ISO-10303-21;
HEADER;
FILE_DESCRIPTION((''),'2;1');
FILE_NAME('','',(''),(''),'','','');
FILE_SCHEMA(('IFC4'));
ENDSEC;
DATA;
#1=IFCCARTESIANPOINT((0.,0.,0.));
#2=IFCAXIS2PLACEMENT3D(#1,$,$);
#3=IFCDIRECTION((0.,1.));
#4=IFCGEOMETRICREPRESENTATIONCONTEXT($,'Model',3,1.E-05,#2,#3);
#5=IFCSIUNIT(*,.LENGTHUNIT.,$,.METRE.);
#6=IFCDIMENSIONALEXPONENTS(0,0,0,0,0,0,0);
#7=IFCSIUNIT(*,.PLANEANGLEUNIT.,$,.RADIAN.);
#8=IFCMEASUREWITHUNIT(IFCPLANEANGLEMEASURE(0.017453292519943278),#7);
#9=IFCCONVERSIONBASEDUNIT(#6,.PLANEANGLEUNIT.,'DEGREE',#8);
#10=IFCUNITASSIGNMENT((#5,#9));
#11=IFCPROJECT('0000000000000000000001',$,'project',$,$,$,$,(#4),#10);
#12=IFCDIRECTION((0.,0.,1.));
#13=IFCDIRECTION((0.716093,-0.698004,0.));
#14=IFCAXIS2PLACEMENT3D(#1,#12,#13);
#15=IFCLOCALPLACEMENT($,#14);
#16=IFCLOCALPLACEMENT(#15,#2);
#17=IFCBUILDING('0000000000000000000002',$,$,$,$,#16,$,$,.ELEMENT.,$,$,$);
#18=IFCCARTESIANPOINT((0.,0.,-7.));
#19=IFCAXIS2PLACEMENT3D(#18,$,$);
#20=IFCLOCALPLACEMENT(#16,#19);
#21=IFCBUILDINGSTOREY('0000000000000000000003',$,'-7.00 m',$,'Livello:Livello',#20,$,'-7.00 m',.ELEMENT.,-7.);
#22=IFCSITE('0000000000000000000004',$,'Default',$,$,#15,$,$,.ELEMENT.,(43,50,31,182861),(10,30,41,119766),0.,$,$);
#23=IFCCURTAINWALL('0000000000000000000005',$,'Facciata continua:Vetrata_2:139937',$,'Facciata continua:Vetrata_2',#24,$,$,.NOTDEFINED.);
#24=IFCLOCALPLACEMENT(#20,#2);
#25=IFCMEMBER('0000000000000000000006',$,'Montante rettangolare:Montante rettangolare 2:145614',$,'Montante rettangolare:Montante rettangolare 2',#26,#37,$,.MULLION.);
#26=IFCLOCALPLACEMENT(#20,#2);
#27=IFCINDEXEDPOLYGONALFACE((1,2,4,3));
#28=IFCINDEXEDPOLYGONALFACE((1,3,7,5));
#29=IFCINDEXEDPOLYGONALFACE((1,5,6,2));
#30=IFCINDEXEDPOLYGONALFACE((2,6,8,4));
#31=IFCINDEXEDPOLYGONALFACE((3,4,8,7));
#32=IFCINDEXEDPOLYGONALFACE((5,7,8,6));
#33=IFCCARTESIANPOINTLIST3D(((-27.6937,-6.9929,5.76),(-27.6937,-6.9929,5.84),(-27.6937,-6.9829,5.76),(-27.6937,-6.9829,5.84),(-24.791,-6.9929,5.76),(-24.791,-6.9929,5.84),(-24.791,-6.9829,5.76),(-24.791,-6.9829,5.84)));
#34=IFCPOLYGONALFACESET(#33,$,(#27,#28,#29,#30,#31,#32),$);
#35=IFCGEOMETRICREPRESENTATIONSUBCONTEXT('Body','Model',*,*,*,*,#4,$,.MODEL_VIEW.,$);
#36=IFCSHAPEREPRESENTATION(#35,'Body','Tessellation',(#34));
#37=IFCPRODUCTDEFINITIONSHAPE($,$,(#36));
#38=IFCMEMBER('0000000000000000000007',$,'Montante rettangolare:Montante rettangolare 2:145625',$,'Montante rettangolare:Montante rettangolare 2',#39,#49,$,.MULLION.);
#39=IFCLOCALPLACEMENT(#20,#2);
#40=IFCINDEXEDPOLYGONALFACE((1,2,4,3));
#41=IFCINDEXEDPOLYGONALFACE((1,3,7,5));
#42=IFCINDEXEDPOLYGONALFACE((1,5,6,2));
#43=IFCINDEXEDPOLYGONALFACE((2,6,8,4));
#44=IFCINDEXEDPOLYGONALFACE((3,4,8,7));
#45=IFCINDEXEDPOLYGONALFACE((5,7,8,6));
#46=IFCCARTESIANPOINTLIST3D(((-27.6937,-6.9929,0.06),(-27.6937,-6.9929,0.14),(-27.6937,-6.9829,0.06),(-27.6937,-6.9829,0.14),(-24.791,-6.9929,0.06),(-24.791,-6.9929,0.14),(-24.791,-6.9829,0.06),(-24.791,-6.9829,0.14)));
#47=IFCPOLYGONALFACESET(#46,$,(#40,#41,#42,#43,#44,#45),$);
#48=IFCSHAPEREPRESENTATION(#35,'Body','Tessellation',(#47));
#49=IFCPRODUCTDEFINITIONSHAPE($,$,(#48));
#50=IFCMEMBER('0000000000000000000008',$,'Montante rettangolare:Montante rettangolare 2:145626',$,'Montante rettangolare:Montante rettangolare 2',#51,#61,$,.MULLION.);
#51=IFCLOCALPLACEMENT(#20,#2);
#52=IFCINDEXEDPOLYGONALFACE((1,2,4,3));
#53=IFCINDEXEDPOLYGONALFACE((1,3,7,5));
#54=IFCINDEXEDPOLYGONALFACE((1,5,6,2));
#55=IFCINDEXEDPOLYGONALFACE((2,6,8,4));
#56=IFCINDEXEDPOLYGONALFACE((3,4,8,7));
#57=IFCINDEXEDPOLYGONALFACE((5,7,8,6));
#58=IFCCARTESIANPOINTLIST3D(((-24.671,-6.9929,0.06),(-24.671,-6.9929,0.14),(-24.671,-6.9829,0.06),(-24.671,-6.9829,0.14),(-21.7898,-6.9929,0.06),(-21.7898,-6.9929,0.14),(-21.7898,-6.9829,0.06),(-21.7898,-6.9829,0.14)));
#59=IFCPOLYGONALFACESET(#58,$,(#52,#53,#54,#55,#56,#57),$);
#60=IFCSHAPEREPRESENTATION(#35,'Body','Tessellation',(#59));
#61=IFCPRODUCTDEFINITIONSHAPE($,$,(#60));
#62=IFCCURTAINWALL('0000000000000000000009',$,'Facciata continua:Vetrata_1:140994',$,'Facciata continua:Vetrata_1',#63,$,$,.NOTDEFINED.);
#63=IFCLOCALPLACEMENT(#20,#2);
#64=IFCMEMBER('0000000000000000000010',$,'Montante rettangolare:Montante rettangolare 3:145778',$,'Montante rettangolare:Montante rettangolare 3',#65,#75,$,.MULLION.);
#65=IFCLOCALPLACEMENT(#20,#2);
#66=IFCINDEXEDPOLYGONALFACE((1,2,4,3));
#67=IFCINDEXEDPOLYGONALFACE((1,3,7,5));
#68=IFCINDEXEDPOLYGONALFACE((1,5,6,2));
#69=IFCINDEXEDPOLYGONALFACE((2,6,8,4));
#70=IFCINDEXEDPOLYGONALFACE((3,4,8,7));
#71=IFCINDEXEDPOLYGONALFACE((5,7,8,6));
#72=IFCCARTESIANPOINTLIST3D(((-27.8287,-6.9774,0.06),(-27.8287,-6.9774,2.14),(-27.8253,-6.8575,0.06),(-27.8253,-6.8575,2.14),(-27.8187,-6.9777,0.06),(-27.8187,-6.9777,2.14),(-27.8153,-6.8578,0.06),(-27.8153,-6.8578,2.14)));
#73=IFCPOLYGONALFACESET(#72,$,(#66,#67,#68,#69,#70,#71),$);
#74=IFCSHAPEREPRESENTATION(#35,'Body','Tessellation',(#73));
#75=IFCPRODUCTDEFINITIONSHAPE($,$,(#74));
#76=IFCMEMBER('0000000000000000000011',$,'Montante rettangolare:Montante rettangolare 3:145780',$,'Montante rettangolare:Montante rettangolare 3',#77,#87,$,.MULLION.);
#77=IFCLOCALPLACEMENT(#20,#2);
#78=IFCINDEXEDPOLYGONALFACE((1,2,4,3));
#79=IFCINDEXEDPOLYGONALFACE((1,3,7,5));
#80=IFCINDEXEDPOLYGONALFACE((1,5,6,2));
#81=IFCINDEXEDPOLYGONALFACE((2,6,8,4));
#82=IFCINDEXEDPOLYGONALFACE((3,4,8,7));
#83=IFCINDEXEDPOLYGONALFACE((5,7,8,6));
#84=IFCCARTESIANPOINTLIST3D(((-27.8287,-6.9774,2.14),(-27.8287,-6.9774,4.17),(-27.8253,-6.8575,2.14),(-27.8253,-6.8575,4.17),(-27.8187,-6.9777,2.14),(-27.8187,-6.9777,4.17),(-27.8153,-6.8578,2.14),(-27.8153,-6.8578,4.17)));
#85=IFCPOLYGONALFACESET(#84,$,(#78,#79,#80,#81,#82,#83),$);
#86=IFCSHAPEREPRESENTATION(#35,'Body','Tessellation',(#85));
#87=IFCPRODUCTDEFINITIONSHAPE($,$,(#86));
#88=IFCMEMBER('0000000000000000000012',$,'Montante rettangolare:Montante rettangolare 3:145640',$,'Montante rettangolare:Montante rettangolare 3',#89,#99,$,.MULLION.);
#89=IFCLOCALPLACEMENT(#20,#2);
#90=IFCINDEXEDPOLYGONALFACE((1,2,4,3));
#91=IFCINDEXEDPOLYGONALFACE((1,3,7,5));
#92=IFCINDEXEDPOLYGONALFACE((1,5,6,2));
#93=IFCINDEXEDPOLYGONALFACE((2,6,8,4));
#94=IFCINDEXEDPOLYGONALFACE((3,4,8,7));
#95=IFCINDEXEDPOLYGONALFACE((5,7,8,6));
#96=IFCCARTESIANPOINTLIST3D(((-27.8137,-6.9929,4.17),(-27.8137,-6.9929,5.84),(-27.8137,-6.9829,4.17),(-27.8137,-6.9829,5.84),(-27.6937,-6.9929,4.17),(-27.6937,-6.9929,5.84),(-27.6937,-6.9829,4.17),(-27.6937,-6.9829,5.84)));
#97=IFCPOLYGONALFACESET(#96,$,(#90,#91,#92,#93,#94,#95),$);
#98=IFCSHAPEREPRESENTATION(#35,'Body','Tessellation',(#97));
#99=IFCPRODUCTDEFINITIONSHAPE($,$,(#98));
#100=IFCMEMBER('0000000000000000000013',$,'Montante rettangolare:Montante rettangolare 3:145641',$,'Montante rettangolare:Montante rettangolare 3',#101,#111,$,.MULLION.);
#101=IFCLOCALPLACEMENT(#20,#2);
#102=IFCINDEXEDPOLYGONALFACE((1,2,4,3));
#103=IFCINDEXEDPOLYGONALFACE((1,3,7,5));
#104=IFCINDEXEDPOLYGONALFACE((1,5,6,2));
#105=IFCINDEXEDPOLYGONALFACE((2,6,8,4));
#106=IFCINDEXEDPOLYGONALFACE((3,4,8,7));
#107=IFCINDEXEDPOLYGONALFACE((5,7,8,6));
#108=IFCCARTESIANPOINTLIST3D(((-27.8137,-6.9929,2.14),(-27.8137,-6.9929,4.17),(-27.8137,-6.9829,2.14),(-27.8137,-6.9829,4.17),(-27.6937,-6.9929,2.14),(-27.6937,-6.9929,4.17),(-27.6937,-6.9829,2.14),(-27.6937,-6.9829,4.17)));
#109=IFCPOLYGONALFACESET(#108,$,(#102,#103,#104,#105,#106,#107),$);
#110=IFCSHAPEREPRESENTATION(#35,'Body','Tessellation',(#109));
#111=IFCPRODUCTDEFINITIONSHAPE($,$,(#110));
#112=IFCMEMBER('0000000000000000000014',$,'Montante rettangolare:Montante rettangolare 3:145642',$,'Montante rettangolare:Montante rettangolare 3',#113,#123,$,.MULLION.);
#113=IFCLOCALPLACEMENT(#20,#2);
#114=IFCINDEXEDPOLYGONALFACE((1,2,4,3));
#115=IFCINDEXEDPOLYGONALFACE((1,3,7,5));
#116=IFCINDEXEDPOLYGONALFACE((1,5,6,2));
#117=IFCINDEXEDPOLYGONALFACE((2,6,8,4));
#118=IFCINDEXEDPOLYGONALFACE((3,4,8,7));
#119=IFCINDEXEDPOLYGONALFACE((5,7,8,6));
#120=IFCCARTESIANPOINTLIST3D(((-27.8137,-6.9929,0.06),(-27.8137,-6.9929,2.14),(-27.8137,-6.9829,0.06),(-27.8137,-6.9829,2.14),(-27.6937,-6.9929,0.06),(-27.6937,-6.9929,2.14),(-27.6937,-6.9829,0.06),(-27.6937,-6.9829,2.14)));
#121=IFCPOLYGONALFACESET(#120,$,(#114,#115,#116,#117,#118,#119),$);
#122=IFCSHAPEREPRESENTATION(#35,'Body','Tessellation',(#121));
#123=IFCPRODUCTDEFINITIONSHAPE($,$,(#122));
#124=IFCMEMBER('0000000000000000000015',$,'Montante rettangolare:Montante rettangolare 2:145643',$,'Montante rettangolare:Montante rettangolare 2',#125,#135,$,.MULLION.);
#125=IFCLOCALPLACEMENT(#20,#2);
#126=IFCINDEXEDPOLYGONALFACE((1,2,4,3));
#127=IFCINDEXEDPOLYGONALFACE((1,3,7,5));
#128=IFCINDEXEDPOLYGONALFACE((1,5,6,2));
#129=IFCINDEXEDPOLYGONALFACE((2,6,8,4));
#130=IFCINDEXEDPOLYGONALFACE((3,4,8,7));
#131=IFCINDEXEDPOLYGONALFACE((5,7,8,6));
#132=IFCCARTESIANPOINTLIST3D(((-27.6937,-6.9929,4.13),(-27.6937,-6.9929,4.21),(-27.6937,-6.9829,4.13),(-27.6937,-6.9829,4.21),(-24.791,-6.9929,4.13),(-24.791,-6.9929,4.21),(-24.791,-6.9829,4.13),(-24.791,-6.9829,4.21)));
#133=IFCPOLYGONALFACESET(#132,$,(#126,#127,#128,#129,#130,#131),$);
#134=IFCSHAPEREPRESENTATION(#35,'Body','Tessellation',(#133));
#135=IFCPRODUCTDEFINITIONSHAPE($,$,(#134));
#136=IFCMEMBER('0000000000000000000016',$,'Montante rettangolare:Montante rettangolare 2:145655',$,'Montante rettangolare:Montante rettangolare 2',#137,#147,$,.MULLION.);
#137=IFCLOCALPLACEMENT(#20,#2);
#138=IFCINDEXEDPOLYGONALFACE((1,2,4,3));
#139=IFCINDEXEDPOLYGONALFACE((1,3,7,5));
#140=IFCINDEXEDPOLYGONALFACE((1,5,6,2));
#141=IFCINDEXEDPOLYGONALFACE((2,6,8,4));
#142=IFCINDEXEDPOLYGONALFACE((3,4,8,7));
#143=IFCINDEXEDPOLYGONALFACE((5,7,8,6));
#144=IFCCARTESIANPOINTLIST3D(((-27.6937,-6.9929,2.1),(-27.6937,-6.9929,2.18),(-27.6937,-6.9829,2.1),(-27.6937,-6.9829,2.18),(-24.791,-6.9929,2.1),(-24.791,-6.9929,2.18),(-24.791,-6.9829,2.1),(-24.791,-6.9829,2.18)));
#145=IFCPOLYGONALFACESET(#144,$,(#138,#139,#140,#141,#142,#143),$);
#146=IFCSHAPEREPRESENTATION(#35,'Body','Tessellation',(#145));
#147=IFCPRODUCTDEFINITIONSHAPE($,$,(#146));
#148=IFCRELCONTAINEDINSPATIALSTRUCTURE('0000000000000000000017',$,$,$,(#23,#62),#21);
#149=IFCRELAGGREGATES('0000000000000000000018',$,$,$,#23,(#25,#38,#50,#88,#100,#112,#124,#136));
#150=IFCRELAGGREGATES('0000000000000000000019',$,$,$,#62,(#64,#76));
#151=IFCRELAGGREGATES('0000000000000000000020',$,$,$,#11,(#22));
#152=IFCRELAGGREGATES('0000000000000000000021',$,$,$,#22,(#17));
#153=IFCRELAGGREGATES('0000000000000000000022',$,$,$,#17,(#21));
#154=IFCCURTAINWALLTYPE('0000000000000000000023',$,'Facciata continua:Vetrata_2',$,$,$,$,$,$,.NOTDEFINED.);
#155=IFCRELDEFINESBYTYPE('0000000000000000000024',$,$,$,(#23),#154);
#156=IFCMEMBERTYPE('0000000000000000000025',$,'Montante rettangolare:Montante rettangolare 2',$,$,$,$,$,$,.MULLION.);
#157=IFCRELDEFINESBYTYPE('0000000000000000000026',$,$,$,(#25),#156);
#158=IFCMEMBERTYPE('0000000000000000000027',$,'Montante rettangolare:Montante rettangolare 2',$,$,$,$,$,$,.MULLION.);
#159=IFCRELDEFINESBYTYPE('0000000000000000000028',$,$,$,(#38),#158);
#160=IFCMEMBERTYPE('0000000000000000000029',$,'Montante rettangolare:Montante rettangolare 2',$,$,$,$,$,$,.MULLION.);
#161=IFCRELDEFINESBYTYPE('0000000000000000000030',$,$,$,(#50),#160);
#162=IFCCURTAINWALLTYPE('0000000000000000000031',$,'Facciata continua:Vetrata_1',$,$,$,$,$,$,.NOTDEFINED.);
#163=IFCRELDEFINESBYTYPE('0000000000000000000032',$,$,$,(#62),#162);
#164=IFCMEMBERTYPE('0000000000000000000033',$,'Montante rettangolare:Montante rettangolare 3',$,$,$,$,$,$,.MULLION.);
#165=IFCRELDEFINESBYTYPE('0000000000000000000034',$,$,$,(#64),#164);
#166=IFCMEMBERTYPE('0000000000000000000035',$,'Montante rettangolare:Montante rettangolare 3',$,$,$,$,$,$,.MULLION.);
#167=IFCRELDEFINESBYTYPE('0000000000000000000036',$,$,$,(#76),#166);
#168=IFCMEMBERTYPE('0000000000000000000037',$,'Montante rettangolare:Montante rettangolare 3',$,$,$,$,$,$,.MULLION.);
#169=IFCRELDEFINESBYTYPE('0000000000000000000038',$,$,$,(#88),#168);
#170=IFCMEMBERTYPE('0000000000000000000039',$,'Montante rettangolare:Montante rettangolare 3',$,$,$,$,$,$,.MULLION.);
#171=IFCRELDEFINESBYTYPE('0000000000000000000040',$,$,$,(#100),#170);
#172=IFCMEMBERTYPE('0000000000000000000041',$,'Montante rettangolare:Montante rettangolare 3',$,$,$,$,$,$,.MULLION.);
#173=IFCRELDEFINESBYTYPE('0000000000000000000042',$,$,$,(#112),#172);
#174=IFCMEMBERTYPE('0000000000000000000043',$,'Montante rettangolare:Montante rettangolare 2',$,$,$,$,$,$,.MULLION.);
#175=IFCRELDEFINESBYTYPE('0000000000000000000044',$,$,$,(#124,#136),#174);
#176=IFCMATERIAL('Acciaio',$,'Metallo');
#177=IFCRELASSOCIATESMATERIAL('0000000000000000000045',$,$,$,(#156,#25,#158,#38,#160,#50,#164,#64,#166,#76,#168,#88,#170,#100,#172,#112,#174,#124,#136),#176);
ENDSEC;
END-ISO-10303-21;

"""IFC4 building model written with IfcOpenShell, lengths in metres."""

from ifc_helpers import new_model, entity, si_unit, converted_unit, direction, frame, origin, place, context, subcontext, project, spatial, indexed_curve, outline, extrude, source, transform, mapped, material, type_object, type_shapes, element, aggregate, save


model = new_model("IFC4")

# Units and contexts
model_context = context("Model", 3, precision=1e-05, world=origin(), true_north=direction((0.0, 1.0)))
body_context = subcontext(model_context, "Body", "Model", "MODEL_VIEW")
ifc_project = project(units=[si_unit("LENGTHUNIT", "METRE"), converted_unit("PLANEANGLEUNIT", "DEGREE", entity("IfcPlaneAngleMeasure", 0.017453292519943278), si_unit("PLANEANGLEUNIT", "RADIAN"), dimensions=[0, 0, 0, 0, 0, 0, 0])], contexts=[model_context])

# Site, building, storey
site_placement = place(None, frame((0.0, 0.0, 0.0), z_axis=(0.0, 0.0, 1.0), x_axis=(0.716093, -0.698004, 0.0)))
site = spatial("IfcSite", under=ifc_project, at=site_placement, Name="Default", CompositionType="ELEMENT", RefLatitude=(43, 50, 31, 182861), RefLongitude=(10, 30, 41, 119766), RefElevation=0.0)
building_placement = place(site_placement, origin())
building = spatial("IfcBuilding", under=site, at=building_placement, CompositionType="ELEMENT")
storey_placement = place(building_placement, frame((0.0, 0.0, -7.0)))
storey = spatial("IfcBuildingStorey", under=building, at=storey_placement, Name="-7.00 m", ObjectType="Livello:Livello", LongName="-7.00 m", CompositionType="ELEMENT", Elevation=-7.0)

# Curtain walls, members
curtain_wall_type_1 = type_object("IfcCurtainWallType", Name="Facciata continua:Vetrata_2", PredefinedType="NOTDEFINED")
curtain_wall_1_placement = place(storey_placement, frame((0.0, 0.0, 7.0)))
curtain_wall_1 = element("IfcCurtainWall", 1, at=curtain_wall_1_placement, inside=storey, type_object=curtain_wall_type_1, Name="Facciata continua:Vetrata_2:139937", ObjectType="Facciata continua:Vetrata_2", PredefinedType="NOTDEFINED")
ifc_material_1 = material(Name="Acciaio", Category="Metallo")
member_type_1 = type_object("IfcMemberType", Name="Montante rettangolare:Montante rettangolare 2", PredefinedType="MULLION", material=ifc_material_1)
shared_shape_1 = source(origin(), body_context, "Body", "SweptSolid", [
    extrude(outline(indexed_curve([(-0.04, -0.005), (0.04, -0.005), (0.04, 0.005), (-0.04, 0.005), (-0.04, -0.005)], self_intersect=False)), frame((-0.04, 0.01, -2.9027), z_axis=(0.0, 0.0, 1.0), x_axis=(-1.0, 0.0, 0.0)), (0.0, 0.0, 1.0), 2.9027),
])
type_shapes(member_type_1, [shared_shape_1])
member_1_placement = place(curtain_wall_1_placement, frame((-24.791, -6.9779, -1.16), z_axis=(1.0, 0.0, 0.0), x_axis=(0.0, 0.0, 1.0)))
member_1 = element("IfcMember", 2, at=member_1_placement, type_object=member_type_1, material=ifc_material_1, Name="Montante rettangolare:Montante rettangolare 2:145614", ObjectType="Montante rettangolare:Montante rettangolare 2", PredefinedType="MULLION", context=body_context, shape_type="MappedRepresentation", body=[
    mapped(shared_shape_1, transform((0.0, 0.0, 0.0), scale=1.0)),
])
member_type_2 = type_object("IfcMemberType", Name="Montante rettangolare:Montante rettangolare 2", PredefinedType="MULLION", material=ifc_material_1)
shared_shape_2 = source(origin(), body_context, "Body", "SweptSolid", [
    extrude(outline(indexed_curve([(-0.04, -0.005), (0.04, -0.005), (0.04, 0.005), (-0.04, 0.005), (-0.04, -0.005)], self_intersect=False)), frame((-0.04, 0.01, -2.9027), z_axis=(0.0, 0.0, 1.0), x_axis=(-1.0, 0.0, 0.0)), (0.0, 0.0, 1.0), 2.9027),
])
type_shapes(member_type_2, [shared_shape_2])
member_2_placement = place(curtain_wall_1_placement, frame((-27.6937, -6.9779, -6.94), z_axis=(-1.0, 0.0, 0.0), x_axis=(0.0, 0.0, -1.0)))
member_2 = element("IfcMember", 3, at=member_2_placement, type_object=member_type_2, material=ifc_material_1, Name="Montante rettangolare:Montante rettangolare 2:145625", ObjectType="Montante rettangolare:Montante rettangolare 2", PredefinedType="MULLION", context=body_context, shape_type="MappedRepresentation", body=[
    mapped(shared_shape_2, transform((0.0, 0.0, 0.0), scale=1.0)),
])
member_type_3 = type_object("IfcMemberType", Name="Montante rettangolare:Montante rettangolare 2", PredefinedType="MULLION", material=ifc_material_1)
shared_shape_3 = source(origin(), body_context, "Body", "SweptSolid", [
    extrude(outline(indexed_curve([(-0.04, -0.005), (0.04, -0.005), (0.04, 0.005), (-0.04, 0.005), (-0.04, -0.005)], self_intersect=False)), frame((-0.04, 0.01, -2.8812), z_axis=(0.0, 0.0, 1.0), x_axis=(-1.0, 0.0, 0.0)), (0.0, 0.0, 1.0), 2.8812),
])
type_shapes(member_type_3, [shared_shape_3])
member_3_placement = place(curtain_wall_1_placement, frame((-24.671, -6.9779, -6.94), z_axis=(-1.0, 0.0, 0.0), x_axis=(0.0, 0.0, -1.0)))
member_3 = element("IfcMember", 4, at=member_3_placement, type_object=member_type_3, material=ifc_material_1, Name="Montante rettangolare:Montante rettangolare 2:145626", ObjectType="Montante rettangolare:Montante rettangolare 2", PredefinedType="MULLION", context=body_context, shape_type="MappedRepresentation", body=[
    mapped(shared_shape_3, transform((0.0, 0.0, 0.0), scale=1.0)),
])
curtain_wall_type_2 = type_object("IfcCurtainWallType", Name="Facciata continua:Vetrata_1", PredefinedType="NOTDEFINED")
curtain_wall_2_placement = place(storey_placement, frame((0.0, 0.0, 7.0)))
curtain_wall_2 = element("IfcCurtainWall", 5, at=curtain_wall_2_placement, inside=storey, type_object=curtain_wall_type_2, Name="Facciata continua:Vetrata_1:140994", ObjectType="Facciata continua:Vetrata_1", PredefinedType="NOTDEFINED")
member_type_4 = type_object("IfcMemberType", Name="Montante rettangolare:Montante rettangolare 3", PredefinedType="MULLION", material=ifc_material_1)
shared_shape_4 = source(origin(), body_context, "Body", "SweptSolid", [
    extrude(outline(indexed_curve([(-0.06, -0.005), (0.06, -0.005), (0.06, 0.005), (-0.06, 0.005), (-0.06, -0.005)], self_intersect=False)), frame((-0.06, 0.01, -2.08), z_axis=(0.0, 0.0, 1.0), x_axis=(-1.0, 0.0, 0.0)), (0.0, 0.0, 1.0), 2.08),
])
type_shapes(member_type_4, [shared_shape_4])
member_4_placement = place(curtain_wall_2_placement, frame((-27.8137, -6.9779, -6.94), z_axis=(0.0, 0.0, -1.0), x_axis=(-0.02798, -0.999608, 0.0)))
member_4 = element("IfcMember", 6, at=member_4_placement, type_object=member_type_4, material=ifc_material_1, Name="Montante rettangolare:Montante rettangolare 3:145778", ObjectType="Montante rettangolare:Montante rettangolare 3", PredefinedType="MULLION", context=body_context, shape_type="MappedRepresentation", body=[
    mapped(shared_shape_4, transform((0.0, 0.0, 0.0), scale=1.0)),
])
member_type_5 = type_object("IfcMemberType", Name="Montante rettangolare:Montante rettangolare 3", PredefinedType="MULLION", material=ifc_material_1)
shared_shape_5 = source(origin(), body_context, "Body", "SweptSolid", [
    extrude(outline(indexed_curve([(-0.06, -0.005), (0.06, -0.005), (0.06, 0.005), (-0.06, 0.005), (-0.06, -0.005)], self_intersect=False)), frame((-0.06, 0.01, -2.03), z_axis=(0.0, 0.0, 1.0), x_axis=(-1.0, 0.0, 0.0)), (0.0, 0.0, 1.0), 2.03),
])
type_shapes(member_type_5, [shared_shape_5])
member_5_placement = place(curtain_wall_2_placement, frame((-27.8137, -6.9779, -4.86), z_axis=(0.0, 0.0, -1.0), x_axis=(-0.02798, -0.999608, 0.0)))
member_5 = element("IfcMember", 7, at=member_5_placement, type_object=member_type_5, material=ifc_material_1, Name="Montante rettangolare:Montante rettangolare 3:145780", ObjectType="Montante rettangolare:Montante rettangolare 3", PredefinedType="MULLION", context=body_context, shape_type="MappedRepresentation", body=[
    mapped(shared_shape_5, transform((0.0, 0.0, 0.0), scale=1.0)),
])

# Members
member_type_6 = type_object("IfcMemberType", Name="Montante rettangolare:Montante rettangolare 3", PredefinedType="MULLION", material=ifc_material_1)
shared_shape_6 = source(origin(), body_context, "Body", "SweptSolid", [
    extrude(outline(indexed_curve([(-0.06, -0.005), (0.06, -0.005), (0.06, 0.005), (-0.06, 0.005), (-0.06, -0.005)], self_intersect=False)), frame((-0.06, 0.01, -1.67), z_axis=(0.0, 0.0, 1.0), x_axis=(-1.0, 0.0, 0.0)), (0.0, 0.0, 1.0), 1.67),
])
type_shapes(member_type_6, [shared_shape_6])
member_6_placement = place(curtain_wall_1_placement, frame((-27.8137, -6.9779, -1.16), z_axis=(0.0, 0.0, 1.0), x_axis=(-1.0, 0.0, 0.0)))
member_6 = element("IfcMember", 8, at=member_6_placement, type_object=member_type_6, material=ifc_material_1, Name="Montante rettangolare:Montante rettangolare 3:145640", ObjectType="Montante rettangolare:Montante rettangolare 3", PredefinedType="MULLION", context=body_context, shape_type="MappedRepresentation", body=[
    mapped(shared_shape_6, transform((0.0, 0.0, 0.0), scale=1.0)),
])
member_type_7 = type_object("IfcMemberType", Name="Montante rettangolare:Montante rettangolare 3", PredefinedType="MULLION", material=ifc_material_1)
shared_shape_7 = source(origin(), body_context, "Body", "SweptSolid", [
    extrude(outline(indexed_curve([(-0.06, -0.005), (0.06, -0.005), (0.06, 0.005), (-0.06, 0.005), (-0.06, -0.005)], self_intersect=False)), frame((-0.06, 0.01, -2.03), z_axis=(0.0, 0.0, 1.0), x_axis=(-1.0, 0.0, 0.0)), (0.0, 0.0, 1.0), 2.03),
])
type_shapes(member_type_7, [shared_shape_7])
member_7_placement = place(curtain_wall_1_placement, frame((-27.8137, -6.9779, -2.83), z_axis=(0.0, 0.0, 1.0), x_axis=(-1.0, 0.0, 0.0)))
member_7 = element("IfcMember", 9, at=member_7_placement, type_object=member_type_7, material=ifc_material_1, Name="Montante rettangolare:Montante rettangolare 3:145641", ObjectType="Montante rettangolare:Montante rettangolare 3", PredefinedType="MULLION", context=body_context, shape_type="MappedRepresentation", body=[
    mapped(shared_shape_7, transform((0.0, 0.0, 0.0), scale=1.0)),
])
member_type_8 = type_object("IfcMemberType", Name="Montante rettangolare:Montante rettangolare 3", PredefinedType="MULLION", material=ifc_material_1)
shared_shape_8 = source(origin(), body_context, "Body", "SweptSolid", [
    extrude(outline(indexed_curve([(-0.06, -0.005), (0.06, -0.005), (0.06, 0.005), (-0.06, 0.005), (-0.06, -0.005)], self_intersect=False)), frame((-0.06, 0.01, -2.08), z_axis=(0.0, 0.0, 1.0), x_axis=(-1.0, 0.0, 0.0)), (0.0, 0.0, 1.0), 2.08),
])
type_shapes(member_type_8, [shared_shape_8])
member_8_placement = place(curtain_wall_1_placement, frame((-27.8137, -6.9779, -4.86), z_axis=(0.0, 0.0, 1.0), x_axis=(-1.0, 0.0, 0.0)))
member_8 = element("IfcMember", 10, at=member_8_placement, type_object=member_type_8, material=ifc_material_1, Name="Montante rettangolare:Montante rettangolare 3:145642", ObjectType="Montante rettangolare:Montante rettangolare 3", PredefinedType="MULLION", context=body_context, shape_type="MappedRepresentation", body=[
    mapped(shared_shape_8, transform((0.0, 0.0, 0.0), scale=1.0)),
])
member_type_9 = type_object("IfcMemberType", Name="Montante rettangolare:Montante rettangolare 2", PredefinedType="MULLION", material=ifc_material_1)
shared_shape_9 = source(origin(), body_context, "Body", "SweptSolid", [
    extrude(outline(indexed_curve([(-0.04, -0.005), (0.04, -0.005), (0.04, 0.005), (-0.04, 0.005), (-0.04, -0.005)], self_intersect=False)), frame((0.0, 0.01, -2.9027), z_axis=(0.0, 0.0, 1.0), x_axis=(-1.0, 0.0, 0.0)), (0.0, 0.0, 1.0), 2.9027),
])
type_shapes(member_type_9, [shared_shape_9])
member_9_placement = place(curtain_wall_1_placement, frame((-24.791, -6.9779, -2.83), z_axis=(1.0, 0.0, 0.0), x_axis=(0.0, 0.0, 1.0)))
member_9 = element("IfcMember", 11, at=member_9_placement, type_object=member_type_9, material=ifc_material_1, Name="Montante rettangolare:Montante rettangolare 2:145643", ObjectType="Montante rettangolare:Montante rettangolare 2", PredefinedType="MULLION", context=body_context, shape_type="MappedRepresentation", body=[
    mapped(shared_shape_9, transform((0.0, 0.0, 0.0), scale=1.0)),
])
member_10_placement = place(curtain_wall_1_placement, frame((-24.791, -6.9779, -4.86), z_axis=(1.0, 0.0, 0.0), x_axis=(0.0, 0.0, 1.0)))
member_10 = element("IfcMember", 12, at=member_10_placement, type_object=member_type_9, material=ifc_material_1, Name="Montante rettangolare:Montante rettangolare 2:145655", ObjectType="Montante rettangolare:Montante rettangolare 2", PredefinedType="MULLION", context=body_context, shape_type="MappedRepresentation", body=[
    mapped(shared_shape_9, transform((0.0, 0.0, 0.0), scale=1.0)),
])

aggregate(curtain_wall_1, [member_1, member_2, member_3, member_6, member_7, member_8, member_9, member_10])
aggregate(curtain_wall_2, [member_4, member_5])

save(model, "model.ifc")
